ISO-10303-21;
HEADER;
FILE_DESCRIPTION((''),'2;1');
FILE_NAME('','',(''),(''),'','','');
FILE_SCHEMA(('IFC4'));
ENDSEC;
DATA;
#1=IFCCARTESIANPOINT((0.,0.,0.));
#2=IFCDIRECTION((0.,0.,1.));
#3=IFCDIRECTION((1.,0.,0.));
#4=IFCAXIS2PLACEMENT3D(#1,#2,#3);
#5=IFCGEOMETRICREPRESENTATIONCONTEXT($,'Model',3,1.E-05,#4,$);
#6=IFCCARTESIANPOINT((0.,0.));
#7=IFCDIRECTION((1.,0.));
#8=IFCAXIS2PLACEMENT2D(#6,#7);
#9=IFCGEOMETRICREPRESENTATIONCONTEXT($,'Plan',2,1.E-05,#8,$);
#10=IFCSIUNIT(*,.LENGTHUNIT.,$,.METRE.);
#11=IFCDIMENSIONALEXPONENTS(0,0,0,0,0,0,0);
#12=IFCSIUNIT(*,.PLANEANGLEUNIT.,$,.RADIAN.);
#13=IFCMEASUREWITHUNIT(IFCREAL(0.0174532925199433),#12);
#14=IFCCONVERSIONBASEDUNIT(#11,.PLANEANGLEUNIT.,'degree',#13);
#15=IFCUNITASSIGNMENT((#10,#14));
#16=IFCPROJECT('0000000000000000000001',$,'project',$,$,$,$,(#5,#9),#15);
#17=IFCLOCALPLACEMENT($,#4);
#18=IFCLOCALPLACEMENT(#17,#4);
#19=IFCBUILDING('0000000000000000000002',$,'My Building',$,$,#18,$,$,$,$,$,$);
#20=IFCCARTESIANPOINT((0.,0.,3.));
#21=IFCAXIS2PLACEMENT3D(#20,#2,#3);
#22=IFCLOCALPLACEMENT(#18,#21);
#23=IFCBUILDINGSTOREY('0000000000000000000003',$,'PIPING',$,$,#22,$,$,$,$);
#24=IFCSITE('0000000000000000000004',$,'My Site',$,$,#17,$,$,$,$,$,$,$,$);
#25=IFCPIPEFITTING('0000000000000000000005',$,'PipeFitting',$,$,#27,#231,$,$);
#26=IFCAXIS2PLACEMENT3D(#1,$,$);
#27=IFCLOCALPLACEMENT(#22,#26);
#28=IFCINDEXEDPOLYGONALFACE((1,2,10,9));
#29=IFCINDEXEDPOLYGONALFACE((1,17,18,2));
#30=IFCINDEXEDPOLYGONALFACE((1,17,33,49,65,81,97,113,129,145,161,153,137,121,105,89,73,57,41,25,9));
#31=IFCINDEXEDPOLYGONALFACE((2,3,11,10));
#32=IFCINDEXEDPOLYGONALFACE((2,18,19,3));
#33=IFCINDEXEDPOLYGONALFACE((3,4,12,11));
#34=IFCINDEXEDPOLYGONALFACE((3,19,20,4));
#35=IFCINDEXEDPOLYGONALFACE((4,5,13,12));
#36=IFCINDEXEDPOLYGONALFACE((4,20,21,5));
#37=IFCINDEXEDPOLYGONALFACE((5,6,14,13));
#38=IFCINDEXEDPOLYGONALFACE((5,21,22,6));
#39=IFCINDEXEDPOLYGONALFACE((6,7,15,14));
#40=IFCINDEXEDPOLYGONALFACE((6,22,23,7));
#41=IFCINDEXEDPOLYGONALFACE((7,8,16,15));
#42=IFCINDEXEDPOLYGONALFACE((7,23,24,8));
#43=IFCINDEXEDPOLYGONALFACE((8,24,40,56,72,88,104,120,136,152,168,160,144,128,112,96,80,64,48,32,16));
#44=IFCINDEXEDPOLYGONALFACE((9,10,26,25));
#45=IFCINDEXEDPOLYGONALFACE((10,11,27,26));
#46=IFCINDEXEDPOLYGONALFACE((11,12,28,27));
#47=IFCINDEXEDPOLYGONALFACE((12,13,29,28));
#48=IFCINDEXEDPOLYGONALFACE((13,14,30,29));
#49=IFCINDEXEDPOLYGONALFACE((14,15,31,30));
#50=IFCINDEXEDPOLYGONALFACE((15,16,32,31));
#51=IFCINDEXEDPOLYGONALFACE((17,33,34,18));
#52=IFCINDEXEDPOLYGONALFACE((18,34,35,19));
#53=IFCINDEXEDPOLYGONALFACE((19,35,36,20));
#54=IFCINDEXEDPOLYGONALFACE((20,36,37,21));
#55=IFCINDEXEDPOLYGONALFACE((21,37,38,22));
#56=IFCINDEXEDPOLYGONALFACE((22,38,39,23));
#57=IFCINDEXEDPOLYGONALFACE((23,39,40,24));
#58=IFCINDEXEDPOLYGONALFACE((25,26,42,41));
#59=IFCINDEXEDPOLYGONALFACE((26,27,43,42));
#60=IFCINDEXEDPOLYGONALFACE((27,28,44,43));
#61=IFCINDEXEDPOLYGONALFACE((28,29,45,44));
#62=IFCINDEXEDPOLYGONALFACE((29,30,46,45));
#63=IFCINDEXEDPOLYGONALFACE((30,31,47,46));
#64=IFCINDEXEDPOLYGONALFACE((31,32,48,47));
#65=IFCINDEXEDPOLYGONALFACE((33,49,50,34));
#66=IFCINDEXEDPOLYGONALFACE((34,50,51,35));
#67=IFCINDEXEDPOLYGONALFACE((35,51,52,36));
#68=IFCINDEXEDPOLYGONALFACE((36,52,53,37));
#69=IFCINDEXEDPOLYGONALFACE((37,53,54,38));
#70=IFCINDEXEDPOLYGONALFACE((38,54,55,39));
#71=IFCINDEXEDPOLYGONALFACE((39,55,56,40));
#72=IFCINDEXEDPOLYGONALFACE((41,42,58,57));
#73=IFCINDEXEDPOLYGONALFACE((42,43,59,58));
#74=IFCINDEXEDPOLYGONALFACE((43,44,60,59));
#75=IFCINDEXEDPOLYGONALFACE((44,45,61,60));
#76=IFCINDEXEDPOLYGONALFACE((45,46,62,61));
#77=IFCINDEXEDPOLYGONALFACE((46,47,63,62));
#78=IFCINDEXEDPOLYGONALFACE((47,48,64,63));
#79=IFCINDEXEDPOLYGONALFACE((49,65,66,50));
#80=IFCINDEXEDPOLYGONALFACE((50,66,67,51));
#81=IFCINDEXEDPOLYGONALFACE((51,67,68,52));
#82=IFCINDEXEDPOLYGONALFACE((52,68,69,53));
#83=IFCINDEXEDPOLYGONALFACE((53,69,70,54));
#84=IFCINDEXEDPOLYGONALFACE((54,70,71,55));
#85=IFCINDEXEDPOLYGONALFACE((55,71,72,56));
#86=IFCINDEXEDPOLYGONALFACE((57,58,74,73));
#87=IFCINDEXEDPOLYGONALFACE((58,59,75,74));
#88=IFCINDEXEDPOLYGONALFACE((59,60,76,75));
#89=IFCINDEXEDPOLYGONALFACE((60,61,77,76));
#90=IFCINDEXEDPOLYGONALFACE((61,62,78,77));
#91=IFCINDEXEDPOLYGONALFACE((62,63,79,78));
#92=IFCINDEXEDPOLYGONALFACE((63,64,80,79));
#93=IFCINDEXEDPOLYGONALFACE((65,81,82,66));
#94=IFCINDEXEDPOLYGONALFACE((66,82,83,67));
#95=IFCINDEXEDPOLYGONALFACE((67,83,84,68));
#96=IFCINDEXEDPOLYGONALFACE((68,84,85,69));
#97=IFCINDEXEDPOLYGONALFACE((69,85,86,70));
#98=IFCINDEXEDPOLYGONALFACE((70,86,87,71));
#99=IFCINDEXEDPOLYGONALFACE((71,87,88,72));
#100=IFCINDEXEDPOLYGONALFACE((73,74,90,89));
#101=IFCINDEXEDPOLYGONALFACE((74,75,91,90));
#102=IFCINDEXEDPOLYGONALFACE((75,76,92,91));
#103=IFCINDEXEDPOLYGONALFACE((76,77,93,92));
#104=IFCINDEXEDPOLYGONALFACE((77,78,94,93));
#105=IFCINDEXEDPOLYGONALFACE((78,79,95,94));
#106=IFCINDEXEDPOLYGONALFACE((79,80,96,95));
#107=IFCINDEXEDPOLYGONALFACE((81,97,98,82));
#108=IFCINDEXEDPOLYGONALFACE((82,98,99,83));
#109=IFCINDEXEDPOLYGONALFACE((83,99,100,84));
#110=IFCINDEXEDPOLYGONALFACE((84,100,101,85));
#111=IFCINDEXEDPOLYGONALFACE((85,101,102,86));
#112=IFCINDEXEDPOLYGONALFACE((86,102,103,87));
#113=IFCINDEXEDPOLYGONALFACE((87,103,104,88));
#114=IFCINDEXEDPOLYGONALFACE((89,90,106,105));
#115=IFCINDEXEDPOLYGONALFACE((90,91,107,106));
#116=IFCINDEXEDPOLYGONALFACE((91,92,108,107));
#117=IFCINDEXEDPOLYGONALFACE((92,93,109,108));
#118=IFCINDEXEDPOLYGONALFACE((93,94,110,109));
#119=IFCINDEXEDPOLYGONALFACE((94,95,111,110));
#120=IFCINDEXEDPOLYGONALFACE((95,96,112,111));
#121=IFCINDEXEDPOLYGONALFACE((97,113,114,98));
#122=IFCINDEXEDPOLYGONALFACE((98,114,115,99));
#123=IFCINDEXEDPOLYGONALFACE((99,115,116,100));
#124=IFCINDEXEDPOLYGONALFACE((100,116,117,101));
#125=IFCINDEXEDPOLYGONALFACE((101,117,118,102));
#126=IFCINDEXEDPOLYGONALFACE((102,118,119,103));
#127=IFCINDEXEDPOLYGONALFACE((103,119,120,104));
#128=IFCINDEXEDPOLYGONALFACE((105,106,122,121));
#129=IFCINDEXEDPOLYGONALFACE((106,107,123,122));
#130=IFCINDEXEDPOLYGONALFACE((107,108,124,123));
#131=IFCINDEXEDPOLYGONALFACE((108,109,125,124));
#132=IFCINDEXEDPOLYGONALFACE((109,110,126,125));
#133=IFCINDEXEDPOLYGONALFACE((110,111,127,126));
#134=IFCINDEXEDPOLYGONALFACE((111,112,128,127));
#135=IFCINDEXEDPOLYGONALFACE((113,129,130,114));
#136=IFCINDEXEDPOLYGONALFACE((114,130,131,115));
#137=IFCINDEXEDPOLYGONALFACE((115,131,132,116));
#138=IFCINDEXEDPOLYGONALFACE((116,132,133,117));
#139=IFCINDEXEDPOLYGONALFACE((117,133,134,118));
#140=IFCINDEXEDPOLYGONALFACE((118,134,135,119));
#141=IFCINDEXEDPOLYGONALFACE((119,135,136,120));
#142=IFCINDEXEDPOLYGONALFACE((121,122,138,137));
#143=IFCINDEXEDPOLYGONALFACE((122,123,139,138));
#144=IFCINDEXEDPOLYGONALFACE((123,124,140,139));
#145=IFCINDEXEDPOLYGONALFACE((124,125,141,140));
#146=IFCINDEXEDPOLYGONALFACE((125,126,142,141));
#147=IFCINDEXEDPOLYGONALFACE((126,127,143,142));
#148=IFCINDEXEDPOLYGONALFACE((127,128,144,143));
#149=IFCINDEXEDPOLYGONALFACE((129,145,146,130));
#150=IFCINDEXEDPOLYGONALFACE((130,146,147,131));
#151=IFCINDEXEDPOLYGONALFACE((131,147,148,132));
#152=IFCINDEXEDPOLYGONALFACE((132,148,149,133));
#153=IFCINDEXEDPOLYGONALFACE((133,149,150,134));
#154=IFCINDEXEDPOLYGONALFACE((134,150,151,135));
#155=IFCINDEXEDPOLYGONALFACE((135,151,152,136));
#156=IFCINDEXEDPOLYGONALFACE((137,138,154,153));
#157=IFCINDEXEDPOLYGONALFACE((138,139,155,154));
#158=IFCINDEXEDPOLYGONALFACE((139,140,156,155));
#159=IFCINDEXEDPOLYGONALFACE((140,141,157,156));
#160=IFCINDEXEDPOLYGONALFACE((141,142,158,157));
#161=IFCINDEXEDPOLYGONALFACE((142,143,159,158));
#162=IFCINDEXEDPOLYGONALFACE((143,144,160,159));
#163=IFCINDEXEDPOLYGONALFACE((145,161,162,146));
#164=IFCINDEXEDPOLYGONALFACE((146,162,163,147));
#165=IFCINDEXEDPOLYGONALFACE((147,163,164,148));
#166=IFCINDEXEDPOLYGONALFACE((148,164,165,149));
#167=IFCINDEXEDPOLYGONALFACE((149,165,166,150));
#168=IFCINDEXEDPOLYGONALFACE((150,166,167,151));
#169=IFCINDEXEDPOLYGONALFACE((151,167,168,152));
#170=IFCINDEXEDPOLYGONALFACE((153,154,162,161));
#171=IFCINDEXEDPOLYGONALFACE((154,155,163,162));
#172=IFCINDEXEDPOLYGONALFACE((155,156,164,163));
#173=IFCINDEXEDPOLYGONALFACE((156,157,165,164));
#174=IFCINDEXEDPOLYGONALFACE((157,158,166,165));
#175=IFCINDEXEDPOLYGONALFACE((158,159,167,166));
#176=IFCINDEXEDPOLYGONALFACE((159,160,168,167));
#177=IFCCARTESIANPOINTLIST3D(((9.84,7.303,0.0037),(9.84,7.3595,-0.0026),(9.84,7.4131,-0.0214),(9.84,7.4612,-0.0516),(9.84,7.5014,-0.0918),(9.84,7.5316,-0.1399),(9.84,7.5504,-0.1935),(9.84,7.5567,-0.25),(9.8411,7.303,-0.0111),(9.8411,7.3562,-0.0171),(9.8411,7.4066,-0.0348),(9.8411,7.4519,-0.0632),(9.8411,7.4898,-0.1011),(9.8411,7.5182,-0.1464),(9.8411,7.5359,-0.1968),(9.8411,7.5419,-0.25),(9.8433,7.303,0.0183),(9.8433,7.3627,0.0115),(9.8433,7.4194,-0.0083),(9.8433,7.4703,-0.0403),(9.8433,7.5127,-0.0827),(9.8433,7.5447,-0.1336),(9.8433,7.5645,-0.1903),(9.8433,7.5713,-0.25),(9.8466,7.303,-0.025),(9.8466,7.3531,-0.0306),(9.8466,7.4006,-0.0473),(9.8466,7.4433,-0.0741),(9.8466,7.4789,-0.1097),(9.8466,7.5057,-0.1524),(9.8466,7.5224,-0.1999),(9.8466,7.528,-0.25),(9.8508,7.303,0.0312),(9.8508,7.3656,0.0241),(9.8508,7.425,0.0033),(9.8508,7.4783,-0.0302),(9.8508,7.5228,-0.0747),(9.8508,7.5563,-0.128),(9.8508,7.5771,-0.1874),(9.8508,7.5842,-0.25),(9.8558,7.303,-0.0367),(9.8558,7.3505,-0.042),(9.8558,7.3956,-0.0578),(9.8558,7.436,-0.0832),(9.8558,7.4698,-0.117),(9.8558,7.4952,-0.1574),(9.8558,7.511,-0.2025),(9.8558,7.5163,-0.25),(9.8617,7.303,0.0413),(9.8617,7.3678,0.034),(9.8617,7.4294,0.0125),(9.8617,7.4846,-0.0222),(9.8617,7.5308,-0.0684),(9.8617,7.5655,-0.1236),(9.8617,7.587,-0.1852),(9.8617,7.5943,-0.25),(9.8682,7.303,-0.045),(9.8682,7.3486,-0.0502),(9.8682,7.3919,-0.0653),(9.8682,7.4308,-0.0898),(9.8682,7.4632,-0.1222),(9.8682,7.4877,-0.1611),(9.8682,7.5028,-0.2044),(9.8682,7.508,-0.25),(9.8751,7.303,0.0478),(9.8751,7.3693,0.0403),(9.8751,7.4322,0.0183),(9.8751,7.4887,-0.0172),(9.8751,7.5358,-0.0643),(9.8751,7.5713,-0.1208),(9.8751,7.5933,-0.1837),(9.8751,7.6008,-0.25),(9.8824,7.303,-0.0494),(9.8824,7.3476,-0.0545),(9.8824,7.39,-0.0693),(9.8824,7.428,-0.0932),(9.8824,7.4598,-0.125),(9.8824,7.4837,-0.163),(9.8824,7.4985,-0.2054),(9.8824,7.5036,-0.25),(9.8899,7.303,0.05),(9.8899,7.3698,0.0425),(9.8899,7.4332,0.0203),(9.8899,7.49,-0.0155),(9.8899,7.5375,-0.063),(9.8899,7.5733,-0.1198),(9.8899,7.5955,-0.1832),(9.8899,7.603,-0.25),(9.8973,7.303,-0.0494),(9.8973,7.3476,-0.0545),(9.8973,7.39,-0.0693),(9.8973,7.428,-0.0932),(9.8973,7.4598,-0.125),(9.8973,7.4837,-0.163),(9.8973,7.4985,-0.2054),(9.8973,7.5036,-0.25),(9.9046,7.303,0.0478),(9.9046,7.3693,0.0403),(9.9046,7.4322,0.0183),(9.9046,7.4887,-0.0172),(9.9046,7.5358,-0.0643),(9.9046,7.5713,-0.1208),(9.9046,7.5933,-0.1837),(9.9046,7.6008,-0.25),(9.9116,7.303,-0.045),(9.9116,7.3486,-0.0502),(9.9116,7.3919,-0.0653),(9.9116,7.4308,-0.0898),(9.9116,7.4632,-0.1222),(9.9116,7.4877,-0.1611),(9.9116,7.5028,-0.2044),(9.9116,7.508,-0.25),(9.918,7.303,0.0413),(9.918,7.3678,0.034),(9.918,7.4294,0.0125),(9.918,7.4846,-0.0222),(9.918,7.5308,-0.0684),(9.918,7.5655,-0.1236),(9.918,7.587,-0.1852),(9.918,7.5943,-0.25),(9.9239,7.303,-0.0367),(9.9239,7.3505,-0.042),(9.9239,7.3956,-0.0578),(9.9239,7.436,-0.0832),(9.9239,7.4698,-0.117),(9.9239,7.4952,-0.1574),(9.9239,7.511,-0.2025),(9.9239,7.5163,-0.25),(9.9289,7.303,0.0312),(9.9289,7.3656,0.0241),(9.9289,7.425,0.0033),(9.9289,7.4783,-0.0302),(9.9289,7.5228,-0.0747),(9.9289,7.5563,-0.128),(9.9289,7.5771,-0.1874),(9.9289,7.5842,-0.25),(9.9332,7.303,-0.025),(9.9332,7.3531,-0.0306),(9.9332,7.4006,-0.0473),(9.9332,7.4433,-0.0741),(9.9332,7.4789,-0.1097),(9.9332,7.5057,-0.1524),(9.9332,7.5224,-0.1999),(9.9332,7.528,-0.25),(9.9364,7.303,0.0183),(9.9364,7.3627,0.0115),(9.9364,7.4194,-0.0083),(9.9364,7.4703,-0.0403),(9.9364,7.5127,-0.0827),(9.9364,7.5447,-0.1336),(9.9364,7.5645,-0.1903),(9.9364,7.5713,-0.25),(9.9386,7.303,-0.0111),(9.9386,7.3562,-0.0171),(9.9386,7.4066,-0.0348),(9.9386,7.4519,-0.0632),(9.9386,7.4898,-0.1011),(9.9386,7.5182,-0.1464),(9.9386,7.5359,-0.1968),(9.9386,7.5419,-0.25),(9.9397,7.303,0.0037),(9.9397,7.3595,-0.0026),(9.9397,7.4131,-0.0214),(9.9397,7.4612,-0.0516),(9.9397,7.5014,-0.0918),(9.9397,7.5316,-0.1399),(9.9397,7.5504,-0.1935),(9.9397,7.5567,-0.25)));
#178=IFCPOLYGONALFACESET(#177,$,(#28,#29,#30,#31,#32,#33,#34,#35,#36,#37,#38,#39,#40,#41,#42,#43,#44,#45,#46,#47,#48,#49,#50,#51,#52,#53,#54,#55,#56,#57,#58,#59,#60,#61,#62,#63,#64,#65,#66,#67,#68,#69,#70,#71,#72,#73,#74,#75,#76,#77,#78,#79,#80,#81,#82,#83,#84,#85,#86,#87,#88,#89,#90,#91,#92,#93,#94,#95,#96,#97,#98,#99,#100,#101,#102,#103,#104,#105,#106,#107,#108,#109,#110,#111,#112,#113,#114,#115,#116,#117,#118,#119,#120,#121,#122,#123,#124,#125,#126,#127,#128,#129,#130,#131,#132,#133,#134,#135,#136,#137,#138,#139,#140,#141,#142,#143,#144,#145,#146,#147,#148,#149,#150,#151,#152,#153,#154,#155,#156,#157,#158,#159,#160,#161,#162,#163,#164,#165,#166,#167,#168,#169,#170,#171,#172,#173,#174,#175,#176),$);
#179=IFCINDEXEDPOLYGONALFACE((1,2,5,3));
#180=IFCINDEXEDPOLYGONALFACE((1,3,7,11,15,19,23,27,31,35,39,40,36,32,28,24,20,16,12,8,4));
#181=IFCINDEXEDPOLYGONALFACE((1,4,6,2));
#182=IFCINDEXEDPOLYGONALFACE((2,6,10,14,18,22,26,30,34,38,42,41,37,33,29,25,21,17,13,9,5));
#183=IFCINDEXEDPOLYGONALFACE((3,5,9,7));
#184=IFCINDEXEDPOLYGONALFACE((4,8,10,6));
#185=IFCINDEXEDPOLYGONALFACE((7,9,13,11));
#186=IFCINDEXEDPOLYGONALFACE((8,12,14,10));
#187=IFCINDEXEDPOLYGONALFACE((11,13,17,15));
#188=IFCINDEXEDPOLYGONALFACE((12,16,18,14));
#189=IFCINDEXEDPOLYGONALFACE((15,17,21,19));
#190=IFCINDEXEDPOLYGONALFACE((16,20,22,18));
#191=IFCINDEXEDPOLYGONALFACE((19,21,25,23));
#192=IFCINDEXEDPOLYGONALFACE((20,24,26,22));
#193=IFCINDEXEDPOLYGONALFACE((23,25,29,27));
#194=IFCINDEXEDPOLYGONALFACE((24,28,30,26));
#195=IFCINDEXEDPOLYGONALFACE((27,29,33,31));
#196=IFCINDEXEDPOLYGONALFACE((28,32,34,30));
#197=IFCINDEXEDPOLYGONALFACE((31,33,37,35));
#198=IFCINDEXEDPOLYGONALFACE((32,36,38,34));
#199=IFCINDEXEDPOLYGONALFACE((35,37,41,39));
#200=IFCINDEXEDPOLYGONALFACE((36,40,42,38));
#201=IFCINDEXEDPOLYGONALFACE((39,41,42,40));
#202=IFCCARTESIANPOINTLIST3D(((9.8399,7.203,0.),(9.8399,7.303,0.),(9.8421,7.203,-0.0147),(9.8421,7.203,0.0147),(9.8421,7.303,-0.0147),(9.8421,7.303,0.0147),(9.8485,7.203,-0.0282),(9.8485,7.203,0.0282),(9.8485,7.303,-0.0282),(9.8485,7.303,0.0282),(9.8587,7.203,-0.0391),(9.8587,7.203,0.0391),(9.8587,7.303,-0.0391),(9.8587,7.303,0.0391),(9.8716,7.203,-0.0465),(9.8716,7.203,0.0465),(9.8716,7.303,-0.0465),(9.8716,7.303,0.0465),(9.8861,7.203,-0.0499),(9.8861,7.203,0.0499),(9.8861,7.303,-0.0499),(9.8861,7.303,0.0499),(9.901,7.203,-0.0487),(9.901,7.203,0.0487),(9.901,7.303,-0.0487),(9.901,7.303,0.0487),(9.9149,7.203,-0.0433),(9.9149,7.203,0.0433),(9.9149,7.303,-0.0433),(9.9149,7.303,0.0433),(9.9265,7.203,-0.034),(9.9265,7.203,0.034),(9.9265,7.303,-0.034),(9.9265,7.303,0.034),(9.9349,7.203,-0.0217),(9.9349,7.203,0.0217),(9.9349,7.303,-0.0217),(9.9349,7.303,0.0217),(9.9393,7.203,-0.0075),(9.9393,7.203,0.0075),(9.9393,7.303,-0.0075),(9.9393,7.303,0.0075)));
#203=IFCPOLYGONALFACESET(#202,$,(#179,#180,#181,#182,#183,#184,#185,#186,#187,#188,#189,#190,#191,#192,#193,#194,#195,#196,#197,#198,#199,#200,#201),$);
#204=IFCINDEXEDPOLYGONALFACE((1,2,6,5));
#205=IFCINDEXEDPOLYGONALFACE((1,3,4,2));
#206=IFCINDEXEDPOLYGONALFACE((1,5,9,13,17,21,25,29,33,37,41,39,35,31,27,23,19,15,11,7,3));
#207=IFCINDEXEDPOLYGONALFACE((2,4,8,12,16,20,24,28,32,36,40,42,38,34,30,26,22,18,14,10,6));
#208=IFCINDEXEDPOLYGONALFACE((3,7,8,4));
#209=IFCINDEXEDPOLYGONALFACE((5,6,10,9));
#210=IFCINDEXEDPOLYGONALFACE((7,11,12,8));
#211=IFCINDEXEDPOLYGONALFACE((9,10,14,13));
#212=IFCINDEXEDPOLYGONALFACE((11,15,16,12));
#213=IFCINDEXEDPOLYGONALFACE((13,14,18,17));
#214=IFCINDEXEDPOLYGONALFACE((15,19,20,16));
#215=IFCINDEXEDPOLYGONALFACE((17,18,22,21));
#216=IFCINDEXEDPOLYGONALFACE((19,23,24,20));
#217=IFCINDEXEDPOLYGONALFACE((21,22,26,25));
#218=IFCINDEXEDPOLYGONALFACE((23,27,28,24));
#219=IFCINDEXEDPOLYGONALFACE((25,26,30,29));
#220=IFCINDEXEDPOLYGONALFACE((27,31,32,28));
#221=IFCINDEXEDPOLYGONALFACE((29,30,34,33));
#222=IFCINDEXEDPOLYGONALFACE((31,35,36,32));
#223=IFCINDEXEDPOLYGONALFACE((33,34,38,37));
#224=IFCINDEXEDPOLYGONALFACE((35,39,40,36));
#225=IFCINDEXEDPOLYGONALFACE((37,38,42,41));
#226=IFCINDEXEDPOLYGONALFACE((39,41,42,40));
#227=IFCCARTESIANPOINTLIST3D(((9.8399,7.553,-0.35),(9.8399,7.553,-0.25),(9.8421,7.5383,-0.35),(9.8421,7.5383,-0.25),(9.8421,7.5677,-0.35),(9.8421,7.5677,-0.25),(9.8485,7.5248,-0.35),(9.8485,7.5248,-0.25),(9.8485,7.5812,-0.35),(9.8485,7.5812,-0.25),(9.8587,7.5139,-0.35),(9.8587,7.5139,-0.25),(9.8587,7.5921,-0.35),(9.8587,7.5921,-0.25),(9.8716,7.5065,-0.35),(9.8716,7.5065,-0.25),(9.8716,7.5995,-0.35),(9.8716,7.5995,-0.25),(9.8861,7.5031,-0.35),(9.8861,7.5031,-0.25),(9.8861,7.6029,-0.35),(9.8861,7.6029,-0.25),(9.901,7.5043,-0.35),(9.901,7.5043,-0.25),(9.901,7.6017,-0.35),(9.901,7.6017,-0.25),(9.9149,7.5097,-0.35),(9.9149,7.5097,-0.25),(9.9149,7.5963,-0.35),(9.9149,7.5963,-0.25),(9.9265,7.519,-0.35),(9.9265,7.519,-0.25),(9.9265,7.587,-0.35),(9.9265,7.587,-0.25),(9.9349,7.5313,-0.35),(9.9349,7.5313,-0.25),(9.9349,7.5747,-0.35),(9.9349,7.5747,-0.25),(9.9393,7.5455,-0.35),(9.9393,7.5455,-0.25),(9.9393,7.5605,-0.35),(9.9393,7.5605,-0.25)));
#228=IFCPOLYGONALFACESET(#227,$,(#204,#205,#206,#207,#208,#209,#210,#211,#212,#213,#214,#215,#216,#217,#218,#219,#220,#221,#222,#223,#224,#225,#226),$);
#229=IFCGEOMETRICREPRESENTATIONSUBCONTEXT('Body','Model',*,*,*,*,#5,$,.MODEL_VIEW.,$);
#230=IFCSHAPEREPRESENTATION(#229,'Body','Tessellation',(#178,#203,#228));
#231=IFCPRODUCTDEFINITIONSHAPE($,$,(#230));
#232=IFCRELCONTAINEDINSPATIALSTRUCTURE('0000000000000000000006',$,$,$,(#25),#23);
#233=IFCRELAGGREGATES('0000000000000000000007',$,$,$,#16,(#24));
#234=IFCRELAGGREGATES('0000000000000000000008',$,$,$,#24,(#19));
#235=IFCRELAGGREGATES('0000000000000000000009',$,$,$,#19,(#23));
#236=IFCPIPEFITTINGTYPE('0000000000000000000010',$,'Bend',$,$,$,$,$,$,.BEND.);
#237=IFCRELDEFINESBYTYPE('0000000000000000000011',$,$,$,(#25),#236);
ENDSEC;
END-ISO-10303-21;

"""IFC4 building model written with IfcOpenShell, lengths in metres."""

from ifc_helpers import new_model, entity, si_unit, converted_unit, frame, origin_with_axes, origin_2d_with_axis, place, context, subcontext, project, spatial, circle, extrude, source, transform, mapped, type_object, type_shapes, element, save


model = new_model("IFC4")

# Units and contexts
model_context = context("Model", 3, precision=1e-05, world=origin_with_axes())
plan_context = context("Plan", 2, precision=1e-05, world=origin_2d_with_axis())
body_context = subcontext(model_context, "Body", "Model", "MODEL_VIEW")
ifc_project = project(units=[si_unit("LENGTHUNIT", "METRE"), converted_unit("PLANEANGLEUNIT", "degree", entity("IfcReal", 0.0174532925199433), si_unit("PLANEANGLEUNIT", "RADIAN"), dimensions=[0, 0, 0, 0, 0, 0, 0])], contexts=[model_context, plan_context])

# Site, building, storey
site_placement = place(None, origin_with_axes())
site = spatial("IfcSite", under=ifc_project, at=site_placement, Name="My Site")
building_placement = place(site_placement, origin_with_axes())
building = spatial("IfcBuilding", under=site, at=building_placement, Name="My Building")
storey_placement = place(building_placement, frame((0.0, 0.0, 3.0), z_axis=(0.0, 0.0, 1.0), x_axis=(1.0, 0.0, 0.0)))
storey = spatial("IfcBuildingStorey", under=building, at=storey_placement, Name="PIPING")

# Shared definitions
pipe_fitting_type = type_object("IfcPipeFittingType", Name="Bend", PredefinedType="BEND")
shared_shape = source(origin_with_axes(), body_context, "Body", "SolidModel", [
    entity("IfcSweptDiskSolid", entity("IfcIndexedPolyCurve", entity("IfcCartesianPointList3D", [[0.0, 0.0, -0.1], [0.0, 0.0732, -0.2768], [0.0, 0.25, -0.35]]), [entity("IfcArcIndex", [1, 2, 3])]), 0.05),
    extrude(circle(Radius=0.05), origin_with_axes(), (0.0, 0.0, -1.0), 0.1),
    extrude(circle(Radius=0.05), frame((0.0, 0.25, -0.35), z_axis=(0.0, 1.0, 0.0), x_axis=(1.0, 0.0, 0.0)), (0.0, 0.0, 1.0), 0.1),
])
type_shapes(pipe_fitting_type, [shared_shape])

# Pipe fitting
pipe_fitting_1_placement = place(storey_placement, frame((9.8899, 7.203, 0.0), z_axis=(0.0, -1.0, 0.0), x_axis=(-1.0, 0.0, 0.0)))
element("IfcPipeFitting", 1, at=pipe_fitting_1_placement, inside=storey, type_object=pipe_fitting_type, Name="PipeFitting", context=body_context, shape_type="MappedRepresentation", body=[
    mapped(shared_shape, transform((0.0, 0.0, 0.0), x_axis=(1.0, 0.0, 0.0), y_axis=(0.0, 1.0, 0.0), z_axis=(0.0, 0.0, 1.0), scale=1.0)),
])

save(model, "model.ifc")
